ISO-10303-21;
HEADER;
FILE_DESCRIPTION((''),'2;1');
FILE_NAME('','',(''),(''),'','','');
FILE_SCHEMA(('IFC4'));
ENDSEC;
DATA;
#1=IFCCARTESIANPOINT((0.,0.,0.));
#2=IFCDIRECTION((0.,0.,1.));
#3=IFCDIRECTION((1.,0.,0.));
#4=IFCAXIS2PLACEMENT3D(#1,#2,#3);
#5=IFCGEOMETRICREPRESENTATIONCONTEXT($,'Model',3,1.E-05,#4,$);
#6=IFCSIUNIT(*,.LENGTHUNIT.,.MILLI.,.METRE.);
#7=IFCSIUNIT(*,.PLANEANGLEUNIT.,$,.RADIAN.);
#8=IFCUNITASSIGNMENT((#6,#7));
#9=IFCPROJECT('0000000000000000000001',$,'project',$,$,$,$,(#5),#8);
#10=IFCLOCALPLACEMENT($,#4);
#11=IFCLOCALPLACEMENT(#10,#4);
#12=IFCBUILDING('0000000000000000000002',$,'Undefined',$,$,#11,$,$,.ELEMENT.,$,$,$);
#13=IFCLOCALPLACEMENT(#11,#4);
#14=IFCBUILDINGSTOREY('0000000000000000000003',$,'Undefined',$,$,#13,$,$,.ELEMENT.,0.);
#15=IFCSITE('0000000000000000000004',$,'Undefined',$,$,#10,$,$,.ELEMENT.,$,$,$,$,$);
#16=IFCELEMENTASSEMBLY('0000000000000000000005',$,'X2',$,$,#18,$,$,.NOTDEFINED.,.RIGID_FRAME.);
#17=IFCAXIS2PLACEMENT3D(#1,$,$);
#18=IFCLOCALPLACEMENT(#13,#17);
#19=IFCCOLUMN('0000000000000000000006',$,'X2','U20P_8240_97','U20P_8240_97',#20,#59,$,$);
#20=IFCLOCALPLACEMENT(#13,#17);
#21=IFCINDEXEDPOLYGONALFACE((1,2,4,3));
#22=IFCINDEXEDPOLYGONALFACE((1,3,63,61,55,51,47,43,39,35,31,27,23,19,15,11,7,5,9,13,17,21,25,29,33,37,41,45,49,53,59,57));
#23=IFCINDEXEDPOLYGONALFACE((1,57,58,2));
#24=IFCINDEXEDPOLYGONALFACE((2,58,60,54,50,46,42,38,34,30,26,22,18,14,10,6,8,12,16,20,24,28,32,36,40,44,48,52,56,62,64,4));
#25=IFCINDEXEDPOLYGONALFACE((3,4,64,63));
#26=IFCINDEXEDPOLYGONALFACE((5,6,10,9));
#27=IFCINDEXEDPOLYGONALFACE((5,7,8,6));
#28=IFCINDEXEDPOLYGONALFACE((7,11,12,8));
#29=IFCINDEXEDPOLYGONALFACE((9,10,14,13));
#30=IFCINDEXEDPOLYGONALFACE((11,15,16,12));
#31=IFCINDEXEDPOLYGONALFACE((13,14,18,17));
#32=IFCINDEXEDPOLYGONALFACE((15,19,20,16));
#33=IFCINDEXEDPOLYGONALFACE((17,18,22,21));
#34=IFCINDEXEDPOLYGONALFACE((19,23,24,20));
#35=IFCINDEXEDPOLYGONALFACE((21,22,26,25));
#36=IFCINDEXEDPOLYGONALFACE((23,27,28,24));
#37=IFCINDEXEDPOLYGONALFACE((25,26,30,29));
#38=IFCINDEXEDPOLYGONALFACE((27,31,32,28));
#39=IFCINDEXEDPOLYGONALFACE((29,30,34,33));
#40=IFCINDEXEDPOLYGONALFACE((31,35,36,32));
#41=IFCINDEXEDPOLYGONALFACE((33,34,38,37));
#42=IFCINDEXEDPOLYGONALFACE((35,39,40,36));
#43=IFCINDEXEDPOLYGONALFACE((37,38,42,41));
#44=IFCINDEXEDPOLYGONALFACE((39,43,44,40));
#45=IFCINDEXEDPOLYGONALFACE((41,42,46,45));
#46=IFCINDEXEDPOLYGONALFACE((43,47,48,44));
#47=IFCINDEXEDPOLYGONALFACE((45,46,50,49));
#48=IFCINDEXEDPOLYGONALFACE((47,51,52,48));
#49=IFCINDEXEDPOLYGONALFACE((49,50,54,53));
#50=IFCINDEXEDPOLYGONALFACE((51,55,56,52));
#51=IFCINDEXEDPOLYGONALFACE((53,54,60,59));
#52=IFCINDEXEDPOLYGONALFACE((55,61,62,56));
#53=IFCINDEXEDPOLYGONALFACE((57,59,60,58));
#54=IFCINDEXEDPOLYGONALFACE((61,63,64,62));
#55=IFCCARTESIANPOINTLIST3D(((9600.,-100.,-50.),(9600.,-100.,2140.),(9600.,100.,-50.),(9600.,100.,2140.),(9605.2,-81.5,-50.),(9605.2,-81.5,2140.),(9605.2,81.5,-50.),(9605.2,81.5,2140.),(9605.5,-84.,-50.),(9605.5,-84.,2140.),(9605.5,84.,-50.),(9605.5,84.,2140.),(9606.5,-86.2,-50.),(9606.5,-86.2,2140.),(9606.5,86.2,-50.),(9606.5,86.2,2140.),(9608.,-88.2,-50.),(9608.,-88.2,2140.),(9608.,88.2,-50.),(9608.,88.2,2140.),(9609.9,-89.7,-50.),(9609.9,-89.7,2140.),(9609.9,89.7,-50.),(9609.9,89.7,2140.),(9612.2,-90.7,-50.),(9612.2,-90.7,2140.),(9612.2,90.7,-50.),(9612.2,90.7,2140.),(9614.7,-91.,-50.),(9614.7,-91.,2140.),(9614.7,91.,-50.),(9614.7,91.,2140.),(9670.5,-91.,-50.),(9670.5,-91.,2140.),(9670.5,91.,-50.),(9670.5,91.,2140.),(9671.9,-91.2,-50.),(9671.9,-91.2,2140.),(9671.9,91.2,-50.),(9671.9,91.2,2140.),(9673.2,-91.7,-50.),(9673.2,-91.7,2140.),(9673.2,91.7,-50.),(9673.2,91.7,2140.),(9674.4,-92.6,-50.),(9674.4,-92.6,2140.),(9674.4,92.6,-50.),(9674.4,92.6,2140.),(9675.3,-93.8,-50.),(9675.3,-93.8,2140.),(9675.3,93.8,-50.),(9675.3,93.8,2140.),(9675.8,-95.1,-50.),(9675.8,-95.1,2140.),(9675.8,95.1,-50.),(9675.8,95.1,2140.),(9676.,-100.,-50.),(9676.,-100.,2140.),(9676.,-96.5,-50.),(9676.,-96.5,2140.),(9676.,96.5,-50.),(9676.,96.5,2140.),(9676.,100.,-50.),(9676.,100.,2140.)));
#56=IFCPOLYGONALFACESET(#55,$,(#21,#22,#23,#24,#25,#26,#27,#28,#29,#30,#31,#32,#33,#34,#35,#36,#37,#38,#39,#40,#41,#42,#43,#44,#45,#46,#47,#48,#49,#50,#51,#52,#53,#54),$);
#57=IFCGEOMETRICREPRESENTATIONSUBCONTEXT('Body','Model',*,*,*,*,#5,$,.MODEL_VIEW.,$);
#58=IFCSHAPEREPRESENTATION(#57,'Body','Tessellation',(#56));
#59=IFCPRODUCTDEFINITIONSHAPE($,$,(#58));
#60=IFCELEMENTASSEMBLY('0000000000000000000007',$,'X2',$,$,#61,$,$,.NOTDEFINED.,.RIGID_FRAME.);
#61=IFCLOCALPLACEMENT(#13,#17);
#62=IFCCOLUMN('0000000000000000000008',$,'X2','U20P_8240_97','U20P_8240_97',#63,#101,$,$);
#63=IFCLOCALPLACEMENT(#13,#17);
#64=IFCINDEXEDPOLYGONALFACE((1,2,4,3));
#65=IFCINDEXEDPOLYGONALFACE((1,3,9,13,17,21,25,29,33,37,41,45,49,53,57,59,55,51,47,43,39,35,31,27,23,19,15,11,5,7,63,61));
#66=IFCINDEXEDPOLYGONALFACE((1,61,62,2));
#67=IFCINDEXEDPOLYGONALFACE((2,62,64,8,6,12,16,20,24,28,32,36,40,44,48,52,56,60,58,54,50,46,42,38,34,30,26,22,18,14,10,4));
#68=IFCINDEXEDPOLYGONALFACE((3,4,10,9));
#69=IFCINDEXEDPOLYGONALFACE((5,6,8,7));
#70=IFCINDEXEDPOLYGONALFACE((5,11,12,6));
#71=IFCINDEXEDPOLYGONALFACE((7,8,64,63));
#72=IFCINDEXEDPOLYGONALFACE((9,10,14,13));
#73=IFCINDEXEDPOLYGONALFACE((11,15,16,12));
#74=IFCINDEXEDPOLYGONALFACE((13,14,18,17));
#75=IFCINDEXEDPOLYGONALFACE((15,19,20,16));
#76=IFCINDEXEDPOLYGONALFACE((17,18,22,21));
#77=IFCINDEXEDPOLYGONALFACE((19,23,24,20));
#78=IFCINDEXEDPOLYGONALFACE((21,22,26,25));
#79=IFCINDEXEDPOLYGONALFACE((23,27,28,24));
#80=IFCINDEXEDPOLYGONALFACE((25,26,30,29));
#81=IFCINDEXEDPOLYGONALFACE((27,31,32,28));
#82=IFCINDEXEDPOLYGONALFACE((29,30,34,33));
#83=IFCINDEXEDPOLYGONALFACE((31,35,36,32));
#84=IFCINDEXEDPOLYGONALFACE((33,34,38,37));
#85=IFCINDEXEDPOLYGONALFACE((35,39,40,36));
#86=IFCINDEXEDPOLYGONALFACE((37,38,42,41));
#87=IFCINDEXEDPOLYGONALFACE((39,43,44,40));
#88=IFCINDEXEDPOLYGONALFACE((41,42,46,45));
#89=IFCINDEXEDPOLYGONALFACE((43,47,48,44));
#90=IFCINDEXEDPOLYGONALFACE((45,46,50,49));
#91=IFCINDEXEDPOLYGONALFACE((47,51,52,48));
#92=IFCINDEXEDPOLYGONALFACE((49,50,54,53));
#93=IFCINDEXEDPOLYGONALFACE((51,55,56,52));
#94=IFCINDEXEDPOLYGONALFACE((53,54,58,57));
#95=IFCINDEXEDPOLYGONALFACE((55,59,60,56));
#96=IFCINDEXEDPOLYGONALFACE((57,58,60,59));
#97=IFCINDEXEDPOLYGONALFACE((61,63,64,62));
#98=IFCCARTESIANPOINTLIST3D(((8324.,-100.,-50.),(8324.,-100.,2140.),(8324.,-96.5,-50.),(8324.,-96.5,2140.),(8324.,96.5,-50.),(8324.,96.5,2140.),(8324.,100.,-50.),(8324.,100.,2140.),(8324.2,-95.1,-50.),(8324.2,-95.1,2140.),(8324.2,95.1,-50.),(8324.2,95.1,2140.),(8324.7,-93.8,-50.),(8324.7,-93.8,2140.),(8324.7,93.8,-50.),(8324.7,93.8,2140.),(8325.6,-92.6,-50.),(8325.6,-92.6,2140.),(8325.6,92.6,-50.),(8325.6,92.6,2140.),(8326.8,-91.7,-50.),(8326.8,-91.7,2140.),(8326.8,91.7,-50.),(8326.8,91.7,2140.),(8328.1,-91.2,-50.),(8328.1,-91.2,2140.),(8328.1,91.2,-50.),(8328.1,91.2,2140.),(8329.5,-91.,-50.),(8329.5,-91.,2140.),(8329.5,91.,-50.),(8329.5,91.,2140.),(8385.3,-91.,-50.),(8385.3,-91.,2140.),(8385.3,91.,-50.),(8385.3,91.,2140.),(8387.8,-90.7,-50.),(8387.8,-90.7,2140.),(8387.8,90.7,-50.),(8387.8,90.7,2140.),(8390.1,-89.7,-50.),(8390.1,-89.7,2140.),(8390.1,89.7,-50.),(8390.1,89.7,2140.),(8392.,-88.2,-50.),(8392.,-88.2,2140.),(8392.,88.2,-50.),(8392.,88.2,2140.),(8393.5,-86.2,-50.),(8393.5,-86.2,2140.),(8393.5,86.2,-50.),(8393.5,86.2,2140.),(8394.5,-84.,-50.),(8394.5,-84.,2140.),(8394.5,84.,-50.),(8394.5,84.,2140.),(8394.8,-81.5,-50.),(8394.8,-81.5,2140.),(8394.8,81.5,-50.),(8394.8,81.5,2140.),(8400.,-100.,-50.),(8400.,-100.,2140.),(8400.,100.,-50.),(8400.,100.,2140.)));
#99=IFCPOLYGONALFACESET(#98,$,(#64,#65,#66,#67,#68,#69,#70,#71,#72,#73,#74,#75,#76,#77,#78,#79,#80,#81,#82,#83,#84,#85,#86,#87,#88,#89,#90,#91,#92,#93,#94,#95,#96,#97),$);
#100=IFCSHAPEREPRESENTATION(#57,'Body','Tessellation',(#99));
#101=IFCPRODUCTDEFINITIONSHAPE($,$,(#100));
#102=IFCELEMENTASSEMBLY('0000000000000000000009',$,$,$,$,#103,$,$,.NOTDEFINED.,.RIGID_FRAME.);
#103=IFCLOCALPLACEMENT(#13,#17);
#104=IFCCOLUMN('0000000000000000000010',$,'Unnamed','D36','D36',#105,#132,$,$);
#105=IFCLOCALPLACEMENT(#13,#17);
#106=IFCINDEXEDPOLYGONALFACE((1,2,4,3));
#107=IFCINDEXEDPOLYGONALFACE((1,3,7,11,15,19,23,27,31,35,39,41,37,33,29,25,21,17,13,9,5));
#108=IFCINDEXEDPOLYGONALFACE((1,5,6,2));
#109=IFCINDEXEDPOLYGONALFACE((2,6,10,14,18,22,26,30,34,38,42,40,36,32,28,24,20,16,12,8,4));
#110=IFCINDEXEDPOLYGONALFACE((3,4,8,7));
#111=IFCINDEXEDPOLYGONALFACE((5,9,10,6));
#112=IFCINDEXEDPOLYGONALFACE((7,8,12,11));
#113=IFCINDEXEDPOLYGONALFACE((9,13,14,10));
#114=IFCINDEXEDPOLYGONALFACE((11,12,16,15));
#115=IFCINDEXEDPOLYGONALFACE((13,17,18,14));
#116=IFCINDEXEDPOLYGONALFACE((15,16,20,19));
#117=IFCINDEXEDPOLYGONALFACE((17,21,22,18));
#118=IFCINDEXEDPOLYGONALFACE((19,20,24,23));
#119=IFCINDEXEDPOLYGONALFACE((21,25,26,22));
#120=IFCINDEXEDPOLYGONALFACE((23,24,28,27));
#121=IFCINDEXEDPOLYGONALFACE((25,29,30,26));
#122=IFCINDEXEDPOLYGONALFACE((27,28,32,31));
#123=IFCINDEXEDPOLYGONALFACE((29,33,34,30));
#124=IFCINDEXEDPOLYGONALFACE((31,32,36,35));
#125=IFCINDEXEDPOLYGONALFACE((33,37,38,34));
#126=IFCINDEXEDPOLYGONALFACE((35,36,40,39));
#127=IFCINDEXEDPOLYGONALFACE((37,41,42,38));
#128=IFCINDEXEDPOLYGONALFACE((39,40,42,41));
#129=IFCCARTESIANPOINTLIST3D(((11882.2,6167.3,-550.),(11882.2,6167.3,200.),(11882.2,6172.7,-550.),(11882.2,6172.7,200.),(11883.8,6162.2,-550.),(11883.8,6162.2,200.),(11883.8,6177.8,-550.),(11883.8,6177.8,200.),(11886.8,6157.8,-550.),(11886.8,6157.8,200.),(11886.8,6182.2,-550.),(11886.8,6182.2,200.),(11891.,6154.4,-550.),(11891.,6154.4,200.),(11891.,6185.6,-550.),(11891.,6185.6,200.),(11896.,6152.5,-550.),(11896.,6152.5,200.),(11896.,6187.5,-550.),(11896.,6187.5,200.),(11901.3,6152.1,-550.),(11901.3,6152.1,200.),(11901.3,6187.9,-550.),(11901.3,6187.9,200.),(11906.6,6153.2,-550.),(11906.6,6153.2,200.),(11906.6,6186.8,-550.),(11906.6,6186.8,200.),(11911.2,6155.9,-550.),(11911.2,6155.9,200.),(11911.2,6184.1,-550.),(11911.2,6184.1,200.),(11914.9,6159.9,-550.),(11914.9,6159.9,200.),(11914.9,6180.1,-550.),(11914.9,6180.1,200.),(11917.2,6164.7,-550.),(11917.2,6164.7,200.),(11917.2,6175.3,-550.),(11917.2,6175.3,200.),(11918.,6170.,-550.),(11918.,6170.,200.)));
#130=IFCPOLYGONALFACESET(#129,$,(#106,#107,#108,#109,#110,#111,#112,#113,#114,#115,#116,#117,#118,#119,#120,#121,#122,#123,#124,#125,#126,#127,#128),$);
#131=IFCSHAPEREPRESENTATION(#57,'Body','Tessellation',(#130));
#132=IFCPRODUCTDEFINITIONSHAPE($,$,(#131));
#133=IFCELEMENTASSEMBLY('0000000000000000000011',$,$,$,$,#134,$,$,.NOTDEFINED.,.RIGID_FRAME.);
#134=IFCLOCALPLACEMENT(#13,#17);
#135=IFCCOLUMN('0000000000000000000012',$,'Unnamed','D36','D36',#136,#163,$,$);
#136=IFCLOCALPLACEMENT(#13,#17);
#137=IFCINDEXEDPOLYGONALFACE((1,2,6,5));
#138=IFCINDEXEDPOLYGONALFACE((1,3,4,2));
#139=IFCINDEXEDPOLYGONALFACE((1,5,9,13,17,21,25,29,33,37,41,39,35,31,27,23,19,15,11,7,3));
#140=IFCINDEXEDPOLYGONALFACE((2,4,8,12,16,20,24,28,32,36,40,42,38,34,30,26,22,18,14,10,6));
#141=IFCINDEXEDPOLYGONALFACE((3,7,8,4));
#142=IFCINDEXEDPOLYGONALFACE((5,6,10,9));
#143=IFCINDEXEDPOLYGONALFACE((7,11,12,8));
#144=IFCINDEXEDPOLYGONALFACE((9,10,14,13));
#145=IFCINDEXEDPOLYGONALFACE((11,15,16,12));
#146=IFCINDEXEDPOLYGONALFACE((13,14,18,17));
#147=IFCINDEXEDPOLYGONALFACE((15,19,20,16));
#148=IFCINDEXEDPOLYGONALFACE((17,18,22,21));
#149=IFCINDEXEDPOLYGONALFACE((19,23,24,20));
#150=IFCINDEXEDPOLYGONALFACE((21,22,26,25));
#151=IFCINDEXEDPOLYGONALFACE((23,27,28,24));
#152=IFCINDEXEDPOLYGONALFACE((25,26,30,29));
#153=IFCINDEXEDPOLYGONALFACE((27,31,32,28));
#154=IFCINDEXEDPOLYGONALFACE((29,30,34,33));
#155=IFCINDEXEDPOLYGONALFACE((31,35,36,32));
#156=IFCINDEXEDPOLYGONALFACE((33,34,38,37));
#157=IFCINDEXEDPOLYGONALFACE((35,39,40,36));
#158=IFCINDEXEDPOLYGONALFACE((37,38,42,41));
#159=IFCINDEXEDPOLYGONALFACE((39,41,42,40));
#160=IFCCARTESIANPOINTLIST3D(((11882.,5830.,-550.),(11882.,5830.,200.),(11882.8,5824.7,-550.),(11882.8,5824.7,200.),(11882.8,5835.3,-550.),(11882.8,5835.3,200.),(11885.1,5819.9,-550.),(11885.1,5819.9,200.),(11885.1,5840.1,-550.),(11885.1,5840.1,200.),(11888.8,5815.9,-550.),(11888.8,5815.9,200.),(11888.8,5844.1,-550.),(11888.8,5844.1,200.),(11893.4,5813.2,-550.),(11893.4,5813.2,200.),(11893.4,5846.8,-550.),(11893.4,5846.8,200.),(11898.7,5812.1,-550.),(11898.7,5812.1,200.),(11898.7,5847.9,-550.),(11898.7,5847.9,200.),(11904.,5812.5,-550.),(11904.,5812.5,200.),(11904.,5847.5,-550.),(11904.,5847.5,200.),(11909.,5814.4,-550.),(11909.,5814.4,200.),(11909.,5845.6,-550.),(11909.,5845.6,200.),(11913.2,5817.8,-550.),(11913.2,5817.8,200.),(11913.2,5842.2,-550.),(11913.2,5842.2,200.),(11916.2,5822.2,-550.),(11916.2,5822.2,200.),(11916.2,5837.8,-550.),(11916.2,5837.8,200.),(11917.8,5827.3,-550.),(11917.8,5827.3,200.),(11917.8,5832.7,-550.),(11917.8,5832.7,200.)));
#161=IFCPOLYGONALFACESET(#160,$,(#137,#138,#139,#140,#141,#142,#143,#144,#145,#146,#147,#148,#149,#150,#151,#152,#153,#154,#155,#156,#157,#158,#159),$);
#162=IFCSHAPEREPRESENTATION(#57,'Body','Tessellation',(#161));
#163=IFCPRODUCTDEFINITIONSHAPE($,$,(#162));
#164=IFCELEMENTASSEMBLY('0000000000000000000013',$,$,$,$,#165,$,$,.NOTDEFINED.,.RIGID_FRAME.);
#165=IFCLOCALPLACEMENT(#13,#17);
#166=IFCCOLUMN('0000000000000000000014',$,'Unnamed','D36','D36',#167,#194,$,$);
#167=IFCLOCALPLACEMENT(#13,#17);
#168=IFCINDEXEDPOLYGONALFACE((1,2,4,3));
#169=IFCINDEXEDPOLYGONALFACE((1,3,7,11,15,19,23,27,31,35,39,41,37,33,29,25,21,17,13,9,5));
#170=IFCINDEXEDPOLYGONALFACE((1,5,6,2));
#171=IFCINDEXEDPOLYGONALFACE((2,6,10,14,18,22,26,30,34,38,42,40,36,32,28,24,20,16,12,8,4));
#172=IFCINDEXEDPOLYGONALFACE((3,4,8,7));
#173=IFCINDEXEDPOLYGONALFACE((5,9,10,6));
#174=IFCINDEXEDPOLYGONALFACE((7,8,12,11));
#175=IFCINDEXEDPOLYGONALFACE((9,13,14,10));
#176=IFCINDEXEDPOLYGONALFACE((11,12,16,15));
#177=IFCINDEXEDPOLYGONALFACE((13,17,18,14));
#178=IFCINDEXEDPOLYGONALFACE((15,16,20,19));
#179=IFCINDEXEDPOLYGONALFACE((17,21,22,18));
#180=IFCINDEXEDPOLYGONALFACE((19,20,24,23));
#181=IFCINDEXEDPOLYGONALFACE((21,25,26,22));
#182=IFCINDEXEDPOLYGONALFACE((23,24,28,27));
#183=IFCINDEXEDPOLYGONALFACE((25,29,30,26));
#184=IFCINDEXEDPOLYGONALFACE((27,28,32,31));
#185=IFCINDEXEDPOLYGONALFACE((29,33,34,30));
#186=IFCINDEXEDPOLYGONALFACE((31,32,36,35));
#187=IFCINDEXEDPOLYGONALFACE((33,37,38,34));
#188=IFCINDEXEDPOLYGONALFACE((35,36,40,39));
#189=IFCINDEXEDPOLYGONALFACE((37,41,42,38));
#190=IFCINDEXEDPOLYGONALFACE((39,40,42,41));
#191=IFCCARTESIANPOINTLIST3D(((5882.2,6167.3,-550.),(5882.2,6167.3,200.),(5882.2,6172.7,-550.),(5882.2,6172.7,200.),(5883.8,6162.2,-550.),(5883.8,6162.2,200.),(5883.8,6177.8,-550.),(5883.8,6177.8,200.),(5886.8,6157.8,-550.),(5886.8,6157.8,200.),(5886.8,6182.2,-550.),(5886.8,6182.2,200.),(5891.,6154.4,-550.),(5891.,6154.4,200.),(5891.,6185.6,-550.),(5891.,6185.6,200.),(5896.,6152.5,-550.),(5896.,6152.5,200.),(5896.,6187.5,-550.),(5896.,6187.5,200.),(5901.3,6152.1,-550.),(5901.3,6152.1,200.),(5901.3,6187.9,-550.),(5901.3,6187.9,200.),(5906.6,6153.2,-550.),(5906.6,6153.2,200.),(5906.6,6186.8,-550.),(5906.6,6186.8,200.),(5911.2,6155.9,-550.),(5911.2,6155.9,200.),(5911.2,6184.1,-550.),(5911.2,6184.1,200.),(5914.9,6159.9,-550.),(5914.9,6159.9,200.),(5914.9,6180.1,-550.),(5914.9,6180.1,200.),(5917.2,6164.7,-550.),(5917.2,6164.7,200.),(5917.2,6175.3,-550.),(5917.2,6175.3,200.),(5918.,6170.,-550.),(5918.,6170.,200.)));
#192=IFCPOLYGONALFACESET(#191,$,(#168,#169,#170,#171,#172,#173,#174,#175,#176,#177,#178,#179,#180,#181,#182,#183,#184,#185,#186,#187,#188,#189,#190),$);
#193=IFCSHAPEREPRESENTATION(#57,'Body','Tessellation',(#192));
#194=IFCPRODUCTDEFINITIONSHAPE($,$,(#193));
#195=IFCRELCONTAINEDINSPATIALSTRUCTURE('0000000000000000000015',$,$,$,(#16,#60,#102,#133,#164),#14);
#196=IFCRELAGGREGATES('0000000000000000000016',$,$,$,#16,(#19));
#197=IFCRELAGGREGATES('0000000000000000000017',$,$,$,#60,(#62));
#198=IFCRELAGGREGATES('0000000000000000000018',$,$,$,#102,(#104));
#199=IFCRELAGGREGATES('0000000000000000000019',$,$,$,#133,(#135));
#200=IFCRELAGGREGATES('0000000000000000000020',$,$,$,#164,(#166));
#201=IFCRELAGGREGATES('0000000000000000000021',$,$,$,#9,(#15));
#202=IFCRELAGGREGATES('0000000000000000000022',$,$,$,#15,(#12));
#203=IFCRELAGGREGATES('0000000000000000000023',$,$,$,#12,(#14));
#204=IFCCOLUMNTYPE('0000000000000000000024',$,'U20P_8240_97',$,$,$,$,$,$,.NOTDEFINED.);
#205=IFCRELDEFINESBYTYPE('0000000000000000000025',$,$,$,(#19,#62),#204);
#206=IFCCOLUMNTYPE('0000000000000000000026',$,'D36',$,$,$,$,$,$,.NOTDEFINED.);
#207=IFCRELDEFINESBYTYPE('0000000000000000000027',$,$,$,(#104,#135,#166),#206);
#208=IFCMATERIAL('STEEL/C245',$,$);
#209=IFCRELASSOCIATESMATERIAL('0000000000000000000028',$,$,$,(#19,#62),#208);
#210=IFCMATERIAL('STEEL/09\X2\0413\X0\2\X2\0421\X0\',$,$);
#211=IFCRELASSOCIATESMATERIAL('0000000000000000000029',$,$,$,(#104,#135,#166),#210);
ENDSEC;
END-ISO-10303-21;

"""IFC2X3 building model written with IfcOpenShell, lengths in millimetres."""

from ifc_helpers import new_model, si_unit, frame, origin_with_axes, origin_2d_with_axis, place, context, subcontext, project, spatial, circle, u_section, extrude, material, type_object, element, aggregate, save


model = new_model("IFC2X3")

# Units and contexts
model_context = context("Model", 3, precision=1e-05, world=origin_with_axes())
body_context = subcontext(model_context, "Body", "Model", "MODEL_VIEW")
ifc_project = project(units=[si_unit("LENGTHUNIT", "METRE", prefix="MILLI"), si_unit("PLANEANGLEUNIT", "RADIAN")], contexts=[model_context])

# Site, building, storey
site_placement = place(None, origin_with_axes())
site = spatial("IfcSite", under=ifc_project, at=site_placement, Name="Undefined", CompositionType="ELEMENT")
building_placement = place(site_placement, origin_with_axes())
building = spatial("IfcBuilding", under=site, at=building_placement, Name="Undefined", CompositionType="ELEMENT")
storey_placement = place(building_placement, origin_with_axes())
storey = spatial("IfcBuildingStorey", under=building, at=storey_placement, Name="Undefined", CompositionType="ELEMENT", Elevation=0.0)

# Element assemblies, columns
assembly_1_placement = place(storey_placement, origin_with_axes())
assembly_1 = element("IfcElementAssembly", 1, at=assembly_1_placement, inside=storey, Name="X2", AssemblyPlace="NOTDEFINED", PredefinedType="RIGID_FRAME")
ifc_material_1 = material(Name="STEEL/C245")
column_type_1 = type_object("IfcColumnType", Name="U20P_8240_97", PredefinedType="NOTDEFINED")
column_1_placement = place(assembly_1_placement, frame((9638.0, 0.0, -50.0), z_axis=(0.0, 0.0, 1.0), x_axis=(0.0, -1.0, 0.0)))
column_1 = element("IfcColumn", 2, at=column_1_placement, type_object=column_type_1, material=ifc_material_1, Name="X2", Description="U20P_8240_97", ObjectType="U20P_8240_97", context=body_context, shape_type="SweptSolid", body=[
    extrude(u_section(Depth=200.0, FlangeWidth=76.0, WebThickness=5.2, FlangeThickness=9.0, FilletRadius=9.5, EdgeRadius=5.5, at=origin_2d_with_axis()), frame((0.0, 0.0, 2190.0), z_axis=(0.0, 0.0, -1.0), x_axis=(0.0, 1.0, 0.0)), (0.0, 0.0, 1.0), 2190.0),
])
aggregate(assembly_1, [column_1])
assembly_2_placement = place(storey_placement, origin_with_axes())
assembly_2 = element("IfcElementAssembly", 3, at=assembly_2_placement, inside=storey, Name="X2", AssemblyPlace="NOTDEFINED", PredefinedType="RIGID_FRAME")
column_2_placement = place(assembly_2_placement, frame((8362.0, 0.0, -50.0), z_axis=(0.0, 0.0, 1.0), x_axis=(0.0, 1.0, 0.0)))
column_2 = element("IfcColumn", 4, at=column_2_placement, type_object=column_type_1, material=ifc_material_1, Name="X2", Description="U20P_8240_97", ObjectType="U20P_8240_97", context=body_context, shape_type="SweptSolid", body=[
    extrude(u_section(Depth=200.0, FlangeWidth=76.0, WebThickness=5.2, FlangeThickness=9.0, FilletRadius=9.5, EdgeRadius=5.5, at=origin_2d_with_axis()), frame((0.0, 0.0, 2190.0), z_axis=(0.0, 0.0, -1.0), x_axis=(0.0, 1.0, 0.0)), (0.0, 0.0, 1.0), 2190.0),
])
aggregate(assembly_2, [column_2])
assembly_3_placement = place(storey_placement, origin_with_axes())
assembly_3 = element("IfcElementAssembly", 5, at=assembly_3_placement, inside=storey, AssemblyPlace="NOTDEFINED", PredefinedType="RIGID_FRAME")
ifc_material_2 = material(Name="STEEL/09Г2С")
column_type_2 = type_object("IfcColumnType", Name="D36", PredefinedType="NOTDEFINED")
column_3_placement = place(assembly_3_placement, frame((11900.0, 6170.0, -550.0), z_axis=(0.0, 0.0, 1.0), x_axis=(0.0, -1.0, 0.0)))
column_3 = element("IfcColumn", 6, at=column_3_placement, type_object=column_type_2, material=ifc_material_2, Name="Unnamed", Description="D36", ObjectType="D36", context=body_context, shape_type="SweptSolid", body=[
    extrude(circle(Radius=18.0, at=origin_2d_with_axis()), frame((0.0, 0.0, 750.0), z_axis=(0.0, 0.0, -1.0), x_axis=(0.0, 1.0, 0.0)), (0.0, 0.0, 1.0), 750.0),
])
aggregate(assembly_3, [column_3])
assembly_4_placement = place(storey_placement, origin_with_axes())
assembly_4 = element("IfcElementAssembly", 7, at=assembly_4_placement, inside=storey, AssemblyPlace="NOTDEFINED", PredefinedType="RIGID_FRAME")
column_4_placement = place(assembly_4_placement, frame((11900.0, 5830.0, -550.0), z_axis=(0.0, 0.0, 1.0), x_axis=(0.0, 1.0, 0.0)))
column_4 = element("IfcColumn", 8, at=column_4_placement, type_object=column_type_2, material=ifc_material_2, Name="Unnamed", Description="D36", ObjectType="D36", context=body_context, shape_type="SweptSolid", body=[
    extrude(circle(Radius=18.0, at=origin_2d_with_axis()), frame((0.0, 0.0, 750.0), z_axis=(0.0, 0.0, -1.0), x_axis=(0.0, 1.0, 0.0)), (0.0, 0.0, 1.0), 750.0),
])
aggregate(assembly_4, [column_4])
assembly_5_placement = place(storey_placement, origin_with_axes())
assembly_5 = element("IfcElementAssembly", 9, at=assembly_5_placement, inside=storey, AssemblyPlace="NOTDEFINED", PredefinedType="RIGID_FRAME")
column_5_placement = place(assembly_5_placement, frame((5900.0, 6170.0, -550.0), z_axis=(0.0, 0.0, 1.0), x_axis=(0.0, -1.0, 0.0)))
column_5 = element("IfcColumn", 10, at=column_5_placement, type_object=column_type_2, material=ifc_material_2, Name="Unnamed", Description="D36", ObjectType="D36", context=body_context, shape_type="SweptSolid", body=[
    extrude(circle(Radius=18.0, at=origin_2d_with_axis()), frame((0.0, 0.0, 750.0), z_axis=(0.0, 0.0, -1.0), x_axis=(0.0, 1.0, 0.0)), (0.0, 0.0, 1.0), 750.0),
])
aggregate(assembly_5, [column_5])

save(model, "model.ifc")
